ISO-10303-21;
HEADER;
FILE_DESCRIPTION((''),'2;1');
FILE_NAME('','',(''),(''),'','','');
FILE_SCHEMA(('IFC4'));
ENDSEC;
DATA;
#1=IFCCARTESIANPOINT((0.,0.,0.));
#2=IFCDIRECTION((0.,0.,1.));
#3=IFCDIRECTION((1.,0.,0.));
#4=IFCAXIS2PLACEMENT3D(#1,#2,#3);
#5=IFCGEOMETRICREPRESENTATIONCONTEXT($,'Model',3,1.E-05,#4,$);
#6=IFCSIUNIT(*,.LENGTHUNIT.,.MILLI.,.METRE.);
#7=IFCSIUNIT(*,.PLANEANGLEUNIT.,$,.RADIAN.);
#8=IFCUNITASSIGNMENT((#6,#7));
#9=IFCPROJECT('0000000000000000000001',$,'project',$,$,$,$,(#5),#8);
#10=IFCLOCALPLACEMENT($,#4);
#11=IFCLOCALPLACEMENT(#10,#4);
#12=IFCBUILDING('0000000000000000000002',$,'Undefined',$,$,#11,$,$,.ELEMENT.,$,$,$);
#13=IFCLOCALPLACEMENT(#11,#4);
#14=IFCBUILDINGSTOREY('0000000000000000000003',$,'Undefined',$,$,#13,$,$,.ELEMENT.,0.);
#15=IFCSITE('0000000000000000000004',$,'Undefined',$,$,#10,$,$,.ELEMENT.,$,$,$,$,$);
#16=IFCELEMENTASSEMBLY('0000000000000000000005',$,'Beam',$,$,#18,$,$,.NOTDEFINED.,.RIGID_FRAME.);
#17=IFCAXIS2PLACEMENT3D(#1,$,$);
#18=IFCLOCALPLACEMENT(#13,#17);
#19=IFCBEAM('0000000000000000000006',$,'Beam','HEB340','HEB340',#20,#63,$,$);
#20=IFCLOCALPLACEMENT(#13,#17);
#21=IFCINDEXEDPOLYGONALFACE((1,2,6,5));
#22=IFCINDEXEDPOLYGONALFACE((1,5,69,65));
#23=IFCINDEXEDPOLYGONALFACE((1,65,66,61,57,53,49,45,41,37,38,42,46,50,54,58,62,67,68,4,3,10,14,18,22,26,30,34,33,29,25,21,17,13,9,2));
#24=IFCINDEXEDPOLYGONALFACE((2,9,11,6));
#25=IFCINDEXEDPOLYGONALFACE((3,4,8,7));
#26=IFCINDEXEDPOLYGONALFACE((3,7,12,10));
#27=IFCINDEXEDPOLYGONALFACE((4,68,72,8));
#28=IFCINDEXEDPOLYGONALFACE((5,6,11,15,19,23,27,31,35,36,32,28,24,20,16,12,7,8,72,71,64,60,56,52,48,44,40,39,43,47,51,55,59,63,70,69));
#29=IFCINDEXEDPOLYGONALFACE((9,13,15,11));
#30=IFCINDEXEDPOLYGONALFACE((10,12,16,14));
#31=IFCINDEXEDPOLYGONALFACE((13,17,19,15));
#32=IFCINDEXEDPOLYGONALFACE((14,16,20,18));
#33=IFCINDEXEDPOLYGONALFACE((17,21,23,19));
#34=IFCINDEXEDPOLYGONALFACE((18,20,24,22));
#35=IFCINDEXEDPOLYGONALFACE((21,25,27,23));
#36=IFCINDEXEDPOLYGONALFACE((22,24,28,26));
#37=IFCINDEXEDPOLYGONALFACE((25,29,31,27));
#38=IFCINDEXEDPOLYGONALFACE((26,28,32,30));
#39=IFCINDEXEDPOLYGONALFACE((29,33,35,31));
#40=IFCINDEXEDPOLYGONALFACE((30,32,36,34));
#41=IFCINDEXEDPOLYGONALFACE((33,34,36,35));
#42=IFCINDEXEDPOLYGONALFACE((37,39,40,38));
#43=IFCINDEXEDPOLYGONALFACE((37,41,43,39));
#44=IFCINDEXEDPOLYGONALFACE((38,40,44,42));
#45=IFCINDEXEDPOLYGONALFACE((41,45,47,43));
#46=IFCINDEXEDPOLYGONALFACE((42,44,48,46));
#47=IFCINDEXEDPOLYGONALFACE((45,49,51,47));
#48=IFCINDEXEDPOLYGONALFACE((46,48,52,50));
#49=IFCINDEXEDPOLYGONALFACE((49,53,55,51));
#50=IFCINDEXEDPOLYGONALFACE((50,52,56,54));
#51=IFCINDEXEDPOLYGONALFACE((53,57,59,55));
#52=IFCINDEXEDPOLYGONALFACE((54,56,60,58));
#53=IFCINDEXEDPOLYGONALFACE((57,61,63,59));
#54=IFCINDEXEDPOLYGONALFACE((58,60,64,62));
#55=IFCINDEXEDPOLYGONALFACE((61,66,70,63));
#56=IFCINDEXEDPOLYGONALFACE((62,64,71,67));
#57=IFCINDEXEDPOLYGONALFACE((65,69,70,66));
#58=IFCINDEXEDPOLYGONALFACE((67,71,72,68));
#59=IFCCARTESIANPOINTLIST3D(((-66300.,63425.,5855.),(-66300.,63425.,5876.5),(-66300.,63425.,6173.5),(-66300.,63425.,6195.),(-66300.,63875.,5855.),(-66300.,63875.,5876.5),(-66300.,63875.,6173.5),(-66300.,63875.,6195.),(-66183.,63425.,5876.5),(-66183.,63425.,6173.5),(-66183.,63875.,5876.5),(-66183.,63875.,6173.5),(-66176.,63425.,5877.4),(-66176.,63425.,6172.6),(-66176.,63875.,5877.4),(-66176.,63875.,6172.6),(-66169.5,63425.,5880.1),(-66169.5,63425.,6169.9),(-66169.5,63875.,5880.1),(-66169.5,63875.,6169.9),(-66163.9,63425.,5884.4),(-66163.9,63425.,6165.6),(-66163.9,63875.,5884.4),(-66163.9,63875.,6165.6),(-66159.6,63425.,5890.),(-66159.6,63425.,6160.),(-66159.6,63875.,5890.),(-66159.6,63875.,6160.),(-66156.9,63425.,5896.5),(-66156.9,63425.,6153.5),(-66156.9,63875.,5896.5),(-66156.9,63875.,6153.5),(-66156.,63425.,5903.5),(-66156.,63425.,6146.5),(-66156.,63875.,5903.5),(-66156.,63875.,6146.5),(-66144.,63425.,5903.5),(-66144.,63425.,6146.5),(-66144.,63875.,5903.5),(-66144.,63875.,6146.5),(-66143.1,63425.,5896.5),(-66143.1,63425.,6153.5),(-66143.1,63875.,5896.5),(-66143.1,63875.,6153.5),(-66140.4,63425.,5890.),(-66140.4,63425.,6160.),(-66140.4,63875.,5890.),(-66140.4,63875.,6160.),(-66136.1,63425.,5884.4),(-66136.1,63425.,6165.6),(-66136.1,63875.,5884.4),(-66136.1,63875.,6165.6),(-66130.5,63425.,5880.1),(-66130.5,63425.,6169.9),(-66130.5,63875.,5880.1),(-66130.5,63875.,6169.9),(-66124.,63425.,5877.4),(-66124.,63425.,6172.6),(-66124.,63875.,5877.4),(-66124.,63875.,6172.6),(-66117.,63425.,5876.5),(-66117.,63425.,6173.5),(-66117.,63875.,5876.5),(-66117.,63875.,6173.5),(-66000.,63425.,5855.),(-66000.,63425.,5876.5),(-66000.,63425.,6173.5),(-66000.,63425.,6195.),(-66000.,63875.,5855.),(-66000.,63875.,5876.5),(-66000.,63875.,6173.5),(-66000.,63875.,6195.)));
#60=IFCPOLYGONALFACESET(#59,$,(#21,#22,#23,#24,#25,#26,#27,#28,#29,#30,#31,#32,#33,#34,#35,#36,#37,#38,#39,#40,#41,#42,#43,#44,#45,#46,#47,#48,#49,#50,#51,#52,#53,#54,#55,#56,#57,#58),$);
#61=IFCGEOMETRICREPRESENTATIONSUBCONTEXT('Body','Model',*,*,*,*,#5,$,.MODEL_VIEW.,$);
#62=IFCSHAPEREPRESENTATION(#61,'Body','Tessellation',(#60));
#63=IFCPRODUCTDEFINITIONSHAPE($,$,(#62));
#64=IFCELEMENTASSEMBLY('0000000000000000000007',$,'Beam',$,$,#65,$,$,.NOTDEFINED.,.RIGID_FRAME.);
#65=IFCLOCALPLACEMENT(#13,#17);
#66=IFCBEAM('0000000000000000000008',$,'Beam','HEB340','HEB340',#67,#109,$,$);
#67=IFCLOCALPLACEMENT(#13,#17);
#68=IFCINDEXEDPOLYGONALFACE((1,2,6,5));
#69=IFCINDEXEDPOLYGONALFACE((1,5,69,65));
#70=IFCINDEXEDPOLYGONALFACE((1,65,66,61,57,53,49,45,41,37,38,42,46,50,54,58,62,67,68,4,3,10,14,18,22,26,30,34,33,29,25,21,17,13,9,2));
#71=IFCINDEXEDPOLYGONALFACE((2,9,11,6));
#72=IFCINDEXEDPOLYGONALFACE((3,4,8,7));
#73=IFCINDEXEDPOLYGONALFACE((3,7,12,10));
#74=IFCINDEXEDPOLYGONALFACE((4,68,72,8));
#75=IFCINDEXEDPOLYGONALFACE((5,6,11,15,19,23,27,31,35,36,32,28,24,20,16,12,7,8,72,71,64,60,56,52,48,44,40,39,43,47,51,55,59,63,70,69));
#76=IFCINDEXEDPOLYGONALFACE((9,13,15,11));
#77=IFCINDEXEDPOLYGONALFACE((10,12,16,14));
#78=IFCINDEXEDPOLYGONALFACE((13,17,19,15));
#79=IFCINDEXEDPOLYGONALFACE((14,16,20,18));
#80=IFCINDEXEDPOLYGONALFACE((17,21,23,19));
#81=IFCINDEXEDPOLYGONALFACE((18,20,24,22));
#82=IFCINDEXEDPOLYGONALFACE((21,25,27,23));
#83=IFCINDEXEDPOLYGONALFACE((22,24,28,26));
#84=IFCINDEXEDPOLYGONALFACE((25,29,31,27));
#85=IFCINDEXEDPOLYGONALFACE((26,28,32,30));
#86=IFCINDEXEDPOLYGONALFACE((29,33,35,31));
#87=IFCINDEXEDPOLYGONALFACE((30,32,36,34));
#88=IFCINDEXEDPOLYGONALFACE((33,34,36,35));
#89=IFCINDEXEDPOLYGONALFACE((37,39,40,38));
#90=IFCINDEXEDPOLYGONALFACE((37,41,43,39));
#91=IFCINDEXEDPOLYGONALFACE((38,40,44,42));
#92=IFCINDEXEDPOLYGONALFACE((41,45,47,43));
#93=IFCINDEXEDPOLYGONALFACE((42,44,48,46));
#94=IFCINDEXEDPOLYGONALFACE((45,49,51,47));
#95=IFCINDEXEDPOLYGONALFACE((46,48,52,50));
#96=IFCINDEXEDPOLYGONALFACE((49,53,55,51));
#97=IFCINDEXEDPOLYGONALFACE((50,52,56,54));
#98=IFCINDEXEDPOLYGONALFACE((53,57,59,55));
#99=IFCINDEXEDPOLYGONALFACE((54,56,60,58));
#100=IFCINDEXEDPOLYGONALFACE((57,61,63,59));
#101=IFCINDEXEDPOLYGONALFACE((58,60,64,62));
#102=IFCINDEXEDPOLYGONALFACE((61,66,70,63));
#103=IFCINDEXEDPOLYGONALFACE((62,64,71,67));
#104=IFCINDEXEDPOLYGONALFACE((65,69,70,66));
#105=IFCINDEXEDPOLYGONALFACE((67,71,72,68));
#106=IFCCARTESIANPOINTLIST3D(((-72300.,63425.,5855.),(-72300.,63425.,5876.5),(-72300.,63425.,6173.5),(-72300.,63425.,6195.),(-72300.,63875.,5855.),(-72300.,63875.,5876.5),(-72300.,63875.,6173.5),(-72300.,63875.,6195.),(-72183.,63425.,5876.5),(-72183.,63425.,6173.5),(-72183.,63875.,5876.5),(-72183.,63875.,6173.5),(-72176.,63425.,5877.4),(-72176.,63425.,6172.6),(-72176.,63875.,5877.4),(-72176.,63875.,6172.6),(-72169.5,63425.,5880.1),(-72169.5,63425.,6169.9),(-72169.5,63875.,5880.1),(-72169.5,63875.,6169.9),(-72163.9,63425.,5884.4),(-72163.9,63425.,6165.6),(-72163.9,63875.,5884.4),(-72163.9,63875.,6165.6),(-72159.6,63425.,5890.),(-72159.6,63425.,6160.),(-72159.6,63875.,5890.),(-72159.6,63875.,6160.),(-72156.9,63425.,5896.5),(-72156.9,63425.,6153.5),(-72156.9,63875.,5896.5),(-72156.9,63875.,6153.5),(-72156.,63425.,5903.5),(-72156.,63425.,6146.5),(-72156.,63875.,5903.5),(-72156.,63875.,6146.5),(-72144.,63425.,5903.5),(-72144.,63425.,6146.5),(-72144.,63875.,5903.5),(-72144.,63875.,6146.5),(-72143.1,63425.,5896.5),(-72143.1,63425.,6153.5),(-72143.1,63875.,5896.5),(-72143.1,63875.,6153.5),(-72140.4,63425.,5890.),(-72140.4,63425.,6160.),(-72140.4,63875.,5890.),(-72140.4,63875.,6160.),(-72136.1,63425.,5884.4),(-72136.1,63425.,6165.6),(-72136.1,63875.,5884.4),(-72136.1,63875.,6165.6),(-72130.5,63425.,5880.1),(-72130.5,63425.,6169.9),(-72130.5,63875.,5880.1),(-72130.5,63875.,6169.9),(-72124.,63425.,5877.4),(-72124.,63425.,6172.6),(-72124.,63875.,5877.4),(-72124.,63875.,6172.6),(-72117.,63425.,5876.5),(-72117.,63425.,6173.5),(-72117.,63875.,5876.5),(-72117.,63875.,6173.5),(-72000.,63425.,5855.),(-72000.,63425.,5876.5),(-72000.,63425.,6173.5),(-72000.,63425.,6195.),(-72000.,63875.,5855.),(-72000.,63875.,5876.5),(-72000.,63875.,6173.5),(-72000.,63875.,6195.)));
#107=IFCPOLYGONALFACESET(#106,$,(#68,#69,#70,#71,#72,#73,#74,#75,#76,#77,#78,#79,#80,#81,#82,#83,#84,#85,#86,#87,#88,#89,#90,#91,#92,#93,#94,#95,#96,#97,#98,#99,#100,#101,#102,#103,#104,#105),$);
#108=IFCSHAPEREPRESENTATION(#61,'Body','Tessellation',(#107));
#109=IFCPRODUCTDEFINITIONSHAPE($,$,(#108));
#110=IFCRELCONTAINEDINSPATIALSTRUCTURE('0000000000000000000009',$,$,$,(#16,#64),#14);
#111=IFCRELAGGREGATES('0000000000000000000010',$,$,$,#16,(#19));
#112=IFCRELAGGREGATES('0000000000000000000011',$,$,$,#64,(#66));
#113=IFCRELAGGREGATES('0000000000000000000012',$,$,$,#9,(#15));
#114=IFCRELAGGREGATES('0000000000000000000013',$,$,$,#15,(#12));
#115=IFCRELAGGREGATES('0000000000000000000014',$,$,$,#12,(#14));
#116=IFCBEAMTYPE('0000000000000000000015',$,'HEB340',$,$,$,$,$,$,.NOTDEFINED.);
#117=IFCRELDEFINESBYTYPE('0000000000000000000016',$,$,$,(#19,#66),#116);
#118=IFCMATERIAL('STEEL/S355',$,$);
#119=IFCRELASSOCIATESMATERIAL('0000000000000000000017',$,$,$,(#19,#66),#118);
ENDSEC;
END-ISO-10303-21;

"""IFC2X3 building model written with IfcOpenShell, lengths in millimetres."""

from ifc_helpers import new_model, si_unit, frame, origin_with_axes, origin_2d_with_axis, place, context, subcontext, project, spatial, i_section, extrude, material, type_object, element, aggregate, save


model = new_model("IFC2X3")

# Units and contexts
model_context = context("Model", 3, precision=1e-05, world=origin_with_axes())
body_context = subcontext(model_context, "Body", "Model", "MODEL_VIEW")
ifc_project = project(units=[si_unit("LENGTHUNIT", "METRE", prefix="MILLI"), si_unit("PLANEANGLEUNIT", "RADIAN")], contexts=[model_context])

# Site, building, storey
site_placement = place(None, origin_with_axes())
site = spatial("IfcSite", under=ifc_project, at=site_placement, Name="Undefined", CompositionType="ELEMENT")
building_placement = place(site_placement, origin_with_axes())
building = spatial("IfcBuilding", under=site, at=building_placement, Name="Undefined", CompositionType="ELEMENT")
storey_placement = place(building_placement, origin_with_axes())
storey = spatial("IfcBuildingStorey", under=building, at=storey_placement, Name="Undefined", CompositionType="ELEMENT", Elevation=0.0)

# Element assemblies, beams
ifc_material = material(Name="STEEL/S355")
assembly_1_placement = place(storey_placement, origin_with_axes())
assembly_1 = element("IfcElementAssembly", 1, at=assembly_1_placement, inside=storey, Name="Beam", AssemblyPlace="NOTDEFINED", PredefinedType="RIGID_FRAME")
beam_type_1 = type_object("IfcBeamType", Name="HEB340", PredefinedType="NOTDEFINED")
beam_1_placement = place(assembly_1_placement, frame((-66150.0, 63875.0, 6025.0), z_axis=(0.0, 0.0, 1.0), x_axis=(0.0, -1.0, 0.0)))
beam_1 = element("IfcBeam", 2, at=beam_1_placement, type_object=beam_type_1, material=ifc_material, Name="Beam", Description="HEB340", ObjectType="HEB340", context=body_context, shape_type="SweptSolid", body=[
    extrude(i_section(OverallWidth=300.0, OverallDepth=340.0, WebThickness=12.0, FlangeThickness=21.5, FilletRadius=27.0, at=origin_2d_with_axis()), frame((450.0, 0.0, 0.0), z_axis=(-1.0, 0.0, 0.0), x_axis=(0.0, -1.0, 0.0)), (0.0, 0.0, 1.0), 450.0),
])
aggregate(assembly_1, [beam_1])
assembly_2_placement = place(storey_placement, origin_with_axes())
assembly_2 = element("IfcElementAssembly", 3, at=assembly_2_placement, inside=storey, Name="Beam", AssemblyPlace="NOTDEFINED", PredefinedType="RIGID_FRAME")
beam_2_placement = place(assembly_2_placement, frame((-72150.0, 63875.0, 6025.0), z_axis=(0.0, 0.0, 1.0), x_axis=(0.0, -1.0, 0.0)))
beam_2 = element("IfcBeam", 4, at=beam_2_placement, type_object=beam_type_1, material=ifc_material, Name="Beam", Description="HEB340", ObjectType="HEB340", context=body_context, shape_type="SweptSolid", body=[
    extrude(i_section(OverallWidth=300.0, OverallDepth=340.0, WebThickness=12.0, FlangeThickness=21.5, FilletRadius=27.0, at=origin_2d_with_axis()), frame((450.0, 0.0, 0.0), z_axis=(-1.0, 0.0, 0.0), x_axis=(0.0, -1.0, 0.0)), (0.0, 0.0, 1.0), 450.0),
])
aggregate(assembly_2, [beam_2])

save(model, "model.ifc")
